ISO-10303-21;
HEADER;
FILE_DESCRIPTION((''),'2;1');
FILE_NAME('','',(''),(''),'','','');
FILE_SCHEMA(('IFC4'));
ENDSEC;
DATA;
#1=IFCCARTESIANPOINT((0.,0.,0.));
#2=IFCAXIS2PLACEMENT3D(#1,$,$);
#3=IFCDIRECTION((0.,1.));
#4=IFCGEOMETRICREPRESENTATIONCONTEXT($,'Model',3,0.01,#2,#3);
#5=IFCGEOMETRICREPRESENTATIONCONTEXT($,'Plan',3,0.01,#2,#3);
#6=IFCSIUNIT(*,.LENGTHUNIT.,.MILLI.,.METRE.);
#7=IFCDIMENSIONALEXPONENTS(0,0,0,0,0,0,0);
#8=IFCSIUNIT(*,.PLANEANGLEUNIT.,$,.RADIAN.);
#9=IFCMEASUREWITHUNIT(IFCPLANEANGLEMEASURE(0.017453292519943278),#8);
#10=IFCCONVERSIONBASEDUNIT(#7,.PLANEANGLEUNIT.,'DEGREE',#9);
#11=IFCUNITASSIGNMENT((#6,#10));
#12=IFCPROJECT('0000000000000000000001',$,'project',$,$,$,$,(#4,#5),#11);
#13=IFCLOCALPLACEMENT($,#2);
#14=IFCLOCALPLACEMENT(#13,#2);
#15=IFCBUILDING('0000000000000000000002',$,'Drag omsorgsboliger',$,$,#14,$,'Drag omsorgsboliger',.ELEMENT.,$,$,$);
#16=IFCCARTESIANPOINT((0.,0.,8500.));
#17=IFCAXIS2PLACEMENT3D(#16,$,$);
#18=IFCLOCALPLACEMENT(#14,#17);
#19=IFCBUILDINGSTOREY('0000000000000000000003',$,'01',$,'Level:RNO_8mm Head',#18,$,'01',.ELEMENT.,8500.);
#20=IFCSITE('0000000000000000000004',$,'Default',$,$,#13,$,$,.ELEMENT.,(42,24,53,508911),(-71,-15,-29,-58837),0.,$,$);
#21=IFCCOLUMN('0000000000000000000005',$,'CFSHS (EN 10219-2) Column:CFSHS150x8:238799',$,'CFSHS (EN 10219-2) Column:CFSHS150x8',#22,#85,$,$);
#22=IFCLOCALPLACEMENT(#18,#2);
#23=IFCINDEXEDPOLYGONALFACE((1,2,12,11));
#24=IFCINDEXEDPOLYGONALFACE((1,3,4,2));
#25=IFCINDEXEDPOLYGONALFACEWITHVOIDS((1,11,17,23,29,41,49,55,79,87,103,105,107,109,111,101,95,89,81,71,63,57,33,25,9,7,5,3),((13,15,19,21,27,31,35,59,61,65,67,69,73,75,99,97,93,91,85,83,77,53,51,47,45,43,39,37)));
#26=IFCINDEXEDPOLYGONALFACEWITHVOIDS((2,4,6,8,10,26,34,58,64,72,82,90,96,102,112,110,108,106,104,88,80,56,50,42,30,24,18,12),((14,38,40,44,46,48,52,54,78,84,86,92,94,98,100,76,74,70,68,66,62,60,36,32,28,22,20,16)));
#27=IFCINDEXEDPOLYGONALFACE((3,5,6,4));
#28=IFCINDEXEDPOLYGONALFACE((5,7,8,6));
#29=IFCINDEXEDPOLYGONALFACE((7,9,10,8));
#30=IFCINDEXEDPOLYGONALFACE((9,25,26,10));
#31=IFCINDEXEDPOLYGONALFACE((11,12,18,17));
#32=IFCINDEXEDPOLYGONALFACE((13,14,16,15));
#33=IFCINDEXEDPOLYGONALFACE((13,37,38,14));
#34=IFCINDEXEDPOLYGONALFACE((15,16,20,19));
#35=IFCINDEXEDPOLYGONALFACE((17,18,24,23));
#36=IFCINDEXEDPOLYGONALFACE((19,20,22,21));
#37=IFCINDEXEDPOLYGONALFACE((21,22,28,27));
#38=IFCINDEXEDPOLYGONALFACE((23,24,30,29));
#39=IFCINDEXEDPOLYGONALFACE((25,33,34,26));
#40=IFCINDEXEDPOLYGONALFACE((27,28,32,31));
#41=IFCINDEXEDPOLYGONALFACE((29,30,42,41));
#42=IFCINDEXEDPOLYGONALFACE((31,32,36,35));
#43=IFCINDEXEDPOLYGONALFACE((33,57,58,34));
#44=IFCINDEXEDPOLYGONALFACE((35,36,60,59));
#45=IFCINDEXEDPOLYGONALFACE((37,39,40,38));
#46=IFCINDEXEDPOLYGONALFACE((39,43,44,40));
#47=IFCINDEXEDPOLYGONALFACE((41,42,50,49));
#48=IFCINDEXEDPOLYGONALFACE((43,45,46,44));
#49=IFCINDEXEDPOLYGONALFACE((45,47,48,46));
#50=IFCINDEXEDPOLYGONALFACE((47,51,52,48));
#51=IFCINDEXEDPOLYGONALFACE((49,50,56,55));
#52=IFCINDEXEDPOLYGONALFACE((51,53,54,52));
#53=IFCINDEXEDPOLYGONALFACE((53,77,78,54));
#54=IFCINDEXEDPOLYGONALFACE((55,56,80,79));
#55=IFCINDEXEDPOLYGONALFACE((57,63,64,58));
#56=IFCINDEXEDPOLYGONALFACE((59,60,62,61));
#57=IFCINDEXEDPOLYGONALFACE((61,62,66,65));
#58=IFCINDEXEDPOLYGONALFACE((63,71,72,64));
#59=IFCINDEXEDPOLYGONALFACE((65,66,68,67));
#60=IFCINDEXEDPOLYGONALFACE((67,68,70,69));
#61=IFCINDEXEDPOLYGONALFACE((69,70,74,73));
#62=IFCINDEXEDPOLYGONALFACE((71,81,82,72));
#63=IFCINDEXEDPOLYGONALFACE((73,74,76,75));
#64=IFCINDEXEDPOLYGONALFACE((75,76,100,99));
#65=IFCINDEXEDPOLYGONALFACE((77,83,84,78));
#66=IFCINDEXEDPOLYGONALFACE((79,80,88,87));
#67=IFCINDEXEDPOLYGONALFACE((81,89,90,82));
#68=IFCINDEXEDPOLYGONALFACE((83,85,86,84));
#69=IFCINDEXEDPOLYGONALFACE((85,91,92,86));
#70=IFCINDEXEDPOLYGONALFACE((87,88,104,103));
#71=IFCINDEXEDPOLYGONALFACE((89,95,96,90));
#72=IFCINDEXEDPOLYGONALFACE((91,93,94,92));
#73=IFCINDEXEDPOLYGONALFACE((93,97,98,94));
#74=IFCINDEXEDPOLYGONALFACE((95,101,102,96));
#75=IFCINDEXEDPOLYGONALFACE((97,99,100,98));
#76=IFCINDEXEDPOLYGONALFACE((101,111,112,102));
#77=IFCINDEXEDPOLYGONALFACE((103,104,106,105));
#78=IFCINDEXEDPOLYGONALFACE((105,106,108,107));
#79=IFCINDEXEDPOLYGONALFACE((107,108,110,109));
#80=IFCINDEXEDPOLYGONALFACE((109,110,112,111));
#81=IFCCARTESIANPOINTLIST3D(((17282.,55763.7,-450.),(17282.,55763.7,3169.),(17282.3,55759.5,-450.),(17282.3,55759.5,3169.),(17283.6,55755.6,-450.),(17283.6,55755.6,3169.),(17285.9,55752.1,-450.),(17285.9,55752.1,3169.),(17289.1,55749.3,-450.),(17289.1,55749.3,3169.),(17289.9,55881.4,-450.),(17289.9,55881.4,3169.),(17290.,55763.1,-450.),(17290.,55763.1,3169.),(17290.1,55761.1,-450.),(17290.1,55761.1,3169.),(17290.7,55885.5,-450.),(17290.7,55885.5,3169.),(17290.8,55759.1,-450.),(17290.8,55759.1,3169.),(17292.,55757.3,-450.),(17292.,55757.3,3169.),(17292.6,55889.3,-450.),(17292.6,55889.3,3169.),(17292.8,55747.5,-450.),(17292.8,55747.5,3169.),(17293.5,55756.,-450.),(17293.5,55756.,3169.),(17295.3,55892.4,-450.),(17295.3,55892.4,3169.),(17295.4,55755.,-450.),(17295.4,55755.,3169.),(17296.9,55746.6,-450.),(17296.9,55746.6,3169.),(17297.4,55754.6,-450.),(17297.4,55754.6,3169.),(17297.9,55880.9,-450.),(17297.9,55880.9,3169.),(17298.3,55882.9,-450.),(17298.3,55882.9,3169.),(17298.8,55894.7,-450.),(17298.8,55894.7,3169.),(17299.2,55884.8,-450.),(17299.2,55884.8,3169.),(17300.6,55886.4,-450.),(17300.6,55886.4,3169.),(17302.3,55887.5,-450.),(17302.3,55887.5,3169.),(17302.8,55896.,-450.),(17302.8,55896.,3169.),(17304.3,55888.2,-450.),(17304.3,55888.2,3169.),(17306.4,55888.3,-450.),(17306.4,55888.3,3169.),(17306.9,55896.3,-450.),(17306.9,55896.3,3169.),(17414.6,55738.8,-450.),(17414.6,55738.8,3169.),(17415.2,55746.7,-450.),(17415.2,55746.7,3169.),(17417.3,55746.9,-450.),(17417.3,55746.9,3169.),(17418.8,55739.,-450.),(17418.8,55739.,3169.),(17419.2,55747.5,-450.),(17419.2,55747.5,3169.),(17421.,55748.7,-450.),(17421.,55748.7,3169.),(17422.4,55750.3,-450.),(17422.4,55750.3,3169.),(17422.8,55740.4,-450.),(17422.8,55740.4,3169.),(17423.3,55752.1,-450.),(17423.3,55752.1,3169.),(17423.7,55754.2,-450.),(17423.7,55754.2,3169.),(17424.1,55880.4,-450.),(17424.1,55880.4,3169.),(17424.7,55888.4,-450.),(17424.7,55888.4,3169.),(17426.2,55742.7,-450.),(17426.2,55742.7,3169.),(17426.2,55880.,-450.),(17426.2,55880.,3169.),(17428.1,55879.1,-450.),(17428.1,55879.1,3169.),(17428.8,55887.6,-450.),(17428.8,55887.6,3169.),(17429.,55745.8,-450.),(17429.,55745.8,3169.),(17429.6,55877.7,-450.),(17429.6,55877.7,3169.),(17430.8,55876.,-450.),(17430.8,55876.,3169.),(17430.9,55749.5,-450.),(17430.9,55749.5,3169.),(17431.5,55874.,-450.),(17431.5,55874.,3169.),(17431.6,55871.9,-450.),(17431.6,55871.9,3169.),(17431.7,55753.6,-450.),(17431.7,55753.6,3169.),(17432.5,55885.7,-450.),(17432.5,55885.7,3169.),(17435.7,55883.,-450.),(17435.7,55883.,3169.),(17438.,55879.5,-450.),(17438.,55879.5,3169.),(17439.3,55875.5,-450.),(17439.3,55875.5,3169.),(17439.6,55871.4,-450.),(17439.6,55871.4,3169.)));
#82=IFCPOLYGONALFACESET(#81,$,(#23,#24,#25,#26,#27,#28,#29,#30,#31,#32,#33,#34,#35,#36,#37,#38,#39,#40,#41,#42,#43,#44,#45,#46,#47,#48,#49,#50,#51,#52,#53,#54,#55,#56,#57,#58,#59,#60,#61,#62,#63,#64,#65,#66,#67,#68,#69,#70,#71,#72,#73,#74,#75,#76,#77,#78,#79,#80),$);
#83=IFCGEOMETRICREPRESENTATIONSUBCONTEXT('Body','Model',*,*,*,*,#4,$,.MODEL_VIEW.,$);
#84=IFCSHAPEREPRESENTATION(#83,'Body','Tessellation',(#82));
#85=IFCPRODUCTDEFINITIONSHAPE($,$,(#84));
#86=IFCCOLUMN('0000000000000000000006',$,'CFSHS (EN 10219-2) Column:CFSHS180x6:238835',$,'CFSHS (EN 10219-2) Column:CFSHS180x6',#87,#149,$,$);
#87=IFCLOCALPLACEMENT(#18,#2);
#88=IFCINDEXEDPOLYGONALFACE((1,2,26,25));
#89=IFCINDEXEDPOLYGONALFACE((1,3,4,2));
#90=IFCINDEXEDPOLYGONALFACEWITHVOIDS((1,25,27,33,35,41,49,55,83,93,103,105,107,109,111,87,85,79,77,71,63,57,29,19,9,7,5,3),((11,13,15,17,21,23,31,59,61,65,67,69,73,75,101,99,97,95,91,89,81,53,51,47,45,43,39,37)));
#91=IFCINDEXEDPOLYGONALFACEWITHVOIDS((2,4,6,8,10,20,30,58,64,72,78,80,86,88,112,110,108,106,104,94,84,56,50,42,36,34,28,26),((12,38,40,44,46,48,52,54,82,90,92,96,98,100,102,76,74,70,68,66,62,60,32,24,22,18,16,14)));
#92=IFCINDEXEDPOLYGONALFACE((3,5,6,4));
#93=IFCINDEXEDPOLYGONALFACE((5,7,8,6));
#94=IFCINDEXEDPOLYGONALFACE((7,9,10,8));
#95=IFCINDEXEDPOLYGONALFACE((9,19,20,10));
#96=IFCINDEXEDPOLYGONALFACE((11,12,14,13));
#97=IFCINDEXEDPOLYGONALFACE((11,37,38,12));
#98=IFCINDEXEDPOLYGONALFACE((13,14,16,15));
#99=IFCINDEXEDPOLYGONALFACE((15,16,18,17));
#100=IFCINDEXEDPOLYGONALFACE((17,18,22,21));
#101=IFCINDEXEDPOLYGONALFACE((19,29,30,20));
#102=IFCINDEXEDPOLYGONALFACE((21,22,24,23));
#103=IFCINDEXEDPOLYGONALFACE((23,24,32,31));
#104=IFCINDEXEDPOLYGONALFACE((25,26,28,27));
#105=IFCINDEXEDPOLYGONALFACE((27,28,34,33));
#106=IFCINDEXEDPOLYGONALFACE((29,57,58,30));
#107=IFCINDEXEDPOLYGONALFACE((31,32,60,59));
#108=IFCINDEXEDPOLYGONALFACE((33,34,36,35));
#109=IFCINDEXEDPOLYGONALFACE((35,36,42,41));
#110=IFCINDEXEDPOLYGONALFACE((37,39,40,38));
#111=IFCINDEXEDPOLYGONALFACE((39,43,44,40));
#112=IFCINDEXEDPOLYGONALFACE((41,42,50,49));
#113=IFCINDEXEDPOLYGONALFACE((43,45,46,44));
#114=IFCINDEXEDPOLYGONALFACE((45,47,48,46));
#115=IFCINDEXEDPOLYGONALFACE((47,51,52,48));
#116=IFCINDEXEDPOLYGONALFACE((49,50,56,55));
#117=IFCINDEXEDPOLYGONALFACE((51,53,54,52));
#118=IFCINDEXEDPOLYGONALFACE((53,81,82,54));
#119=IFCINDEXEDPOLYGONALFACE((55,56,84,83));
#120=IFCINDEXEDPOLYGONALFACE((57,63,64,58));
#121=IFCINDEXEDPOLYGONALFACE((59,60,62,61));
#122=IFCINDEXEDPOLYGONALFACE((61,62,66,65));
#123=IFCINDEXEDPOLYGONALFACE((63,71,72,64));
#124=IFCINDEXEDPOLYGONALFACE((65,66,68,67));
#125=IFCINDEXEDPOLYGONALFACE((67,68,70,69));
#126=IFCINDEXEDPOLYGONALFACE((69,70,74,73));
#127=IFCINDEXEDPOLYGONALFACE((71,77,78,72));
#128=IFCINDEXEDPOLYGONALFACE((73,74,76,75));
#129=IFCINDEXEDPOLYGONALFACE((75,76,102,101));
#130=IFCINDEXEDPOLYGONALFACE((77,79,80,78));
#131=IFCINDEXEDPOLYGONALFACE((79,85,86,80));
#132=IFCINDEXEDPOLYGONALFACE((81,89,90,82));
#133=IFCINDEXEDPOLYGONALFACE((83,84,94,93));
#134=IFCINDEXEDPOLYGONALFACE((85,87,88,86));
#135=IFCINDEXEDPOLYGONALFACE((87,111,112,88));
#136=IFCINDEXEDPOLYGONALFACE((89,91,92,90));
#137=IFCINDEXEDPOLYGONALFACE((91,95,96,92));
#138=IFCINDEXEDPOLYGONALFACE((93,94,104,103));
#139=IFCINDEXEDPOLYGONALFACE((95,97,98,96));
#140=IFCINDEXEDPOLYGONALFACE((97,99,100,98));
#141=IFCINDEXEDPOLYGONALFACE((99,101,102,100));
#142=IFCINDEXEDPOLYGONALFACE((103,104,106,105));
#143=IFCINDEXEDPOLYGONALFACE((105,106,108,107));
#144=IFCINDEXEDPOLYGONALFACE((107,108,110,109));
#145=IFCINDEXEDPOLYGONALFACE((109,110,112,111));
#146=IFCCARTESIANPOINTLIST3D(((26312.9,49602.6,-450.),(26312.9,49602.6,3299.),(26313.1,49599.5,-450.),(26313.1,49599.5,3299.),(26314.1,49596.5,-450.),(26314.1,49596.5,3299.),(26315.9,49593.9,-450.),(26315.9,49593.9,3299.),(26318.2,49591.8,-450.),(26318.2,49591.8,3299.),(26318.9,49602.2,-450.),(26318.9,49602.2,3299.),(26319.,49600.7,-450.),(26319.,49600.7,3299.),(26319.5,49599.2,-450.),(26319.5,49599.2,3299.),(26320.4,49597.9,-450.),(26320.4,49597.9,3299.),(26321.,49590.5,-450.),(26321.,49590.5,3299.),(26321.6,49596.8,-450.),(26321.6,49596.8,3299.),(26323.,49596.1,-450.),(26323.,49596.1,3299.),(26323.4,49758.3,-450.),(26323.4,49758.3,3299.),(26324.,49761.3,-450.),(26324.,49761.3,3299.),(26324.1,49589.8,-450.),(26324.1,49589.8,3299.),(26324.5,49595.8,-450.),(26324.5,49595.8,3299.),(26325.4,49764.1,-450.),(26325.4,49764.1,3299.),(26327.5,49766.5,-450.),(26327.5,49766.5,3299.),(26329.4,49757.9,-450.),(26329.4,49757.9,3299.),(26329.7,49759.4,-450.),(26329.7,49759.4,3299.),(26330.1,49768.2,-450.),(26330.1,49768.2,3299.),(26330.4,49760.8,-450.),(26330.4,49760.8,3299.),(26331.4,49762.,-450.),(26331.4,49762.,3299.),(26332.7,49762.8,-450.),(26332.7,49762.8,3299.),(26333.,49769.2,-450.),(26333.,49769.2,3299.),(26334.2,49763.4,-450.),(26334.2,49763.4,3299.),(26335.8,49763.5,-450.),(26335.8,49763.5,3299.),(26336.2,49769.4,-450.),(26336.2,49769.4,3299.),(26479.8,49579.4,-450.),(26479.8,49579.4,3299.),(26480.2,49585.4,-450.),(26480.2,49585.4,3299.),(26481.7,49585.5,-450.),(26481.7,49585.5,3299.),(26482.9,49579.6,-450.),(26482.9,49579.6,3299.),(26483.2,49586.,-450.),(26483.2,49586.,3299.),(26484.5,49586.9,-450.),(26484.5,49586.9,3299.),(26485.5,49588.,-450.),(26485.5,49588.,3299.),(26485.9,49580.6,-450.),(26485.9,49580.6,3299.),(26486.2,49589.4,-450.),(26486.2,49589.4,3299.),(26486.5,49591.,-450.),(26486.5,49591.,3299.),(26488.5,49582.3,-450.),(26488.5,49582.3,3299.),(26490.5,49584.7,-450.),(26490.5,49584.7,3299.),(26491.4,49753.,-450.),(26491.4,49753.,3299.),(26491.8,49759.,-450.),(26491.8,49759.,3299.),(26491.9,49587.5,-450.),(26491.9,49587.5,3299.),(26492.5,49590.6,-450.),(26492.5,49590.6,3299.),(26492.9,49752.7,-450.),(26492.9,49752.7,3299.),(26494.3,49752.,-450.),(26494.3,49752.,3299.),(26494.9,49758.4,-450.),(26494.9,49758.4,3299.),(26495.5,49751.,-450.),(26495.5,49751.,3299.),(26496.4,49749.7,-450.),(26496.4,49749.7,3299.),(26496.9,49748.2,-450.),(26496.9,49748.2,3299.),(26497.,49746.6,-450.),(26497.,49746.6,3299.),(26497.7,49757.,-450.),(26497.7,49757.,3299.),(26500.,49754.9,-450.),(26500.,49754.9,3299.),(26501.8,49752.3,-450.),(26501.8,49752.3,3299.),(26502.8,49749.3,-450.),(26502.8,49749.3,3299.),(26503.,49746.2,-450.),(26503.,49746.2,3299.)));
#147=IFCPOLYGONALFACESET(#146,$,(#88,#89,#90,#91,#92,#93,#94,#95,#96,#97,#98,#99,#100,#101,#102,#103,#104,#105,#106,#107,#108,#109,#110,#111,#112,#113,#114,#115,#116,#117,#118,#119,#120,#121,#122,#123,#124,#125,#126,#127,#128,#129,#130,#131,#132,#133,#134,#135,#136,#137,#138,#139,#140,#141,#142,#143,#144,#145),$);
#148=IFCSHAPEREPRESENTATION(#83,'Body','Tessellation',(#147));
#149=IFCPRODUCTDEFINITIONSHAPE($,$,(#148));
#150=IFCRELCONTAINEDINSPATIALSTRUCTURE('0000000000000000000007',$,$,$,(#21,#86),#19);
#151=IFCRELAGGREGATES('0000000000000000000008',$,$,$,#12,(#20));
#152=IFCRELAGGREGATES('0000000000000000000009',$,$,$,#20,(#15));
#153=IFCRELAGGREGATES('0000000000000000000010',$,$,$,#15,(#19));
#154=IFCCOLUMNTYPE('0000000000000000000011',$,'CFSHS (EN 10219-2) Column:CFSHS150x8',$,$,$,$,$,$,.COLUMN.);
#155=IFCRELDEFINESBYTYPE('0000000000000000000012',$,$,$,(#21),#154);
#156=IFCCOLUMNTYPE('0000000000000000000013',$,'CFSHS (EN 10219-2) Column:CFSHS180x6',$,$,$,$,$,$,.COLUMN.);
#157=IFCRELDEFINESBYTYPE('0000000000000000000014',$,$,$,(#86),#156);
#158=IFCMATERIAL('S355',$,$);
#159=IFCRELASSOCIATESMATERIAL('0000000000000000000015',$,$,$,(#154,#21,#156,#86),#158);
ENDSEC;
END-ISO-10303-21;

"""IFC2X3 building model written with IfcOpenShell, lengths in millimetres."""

from ifc_helpers import new_model, entity, si_unit, converted_unit, direction, frame, frame_2d, origin, place, context, subcontext, project, spatial, polyline, circle_curve, parameter, trimmed, segment, composite_curve, outline, extrude, source, transform, mapped, material, type_object, type_shapes, element, save


model = new_model("IFC2X3")

# Units and contexts
model_context = context("Model", 3, precision=0.01, world=origin(), true_north=direction((0.0, 1.0)))
plan_context = context("Plan", 3, precision=0.01, world=origin(), true_north=direction((0.0, 1.0)))
body_context = subcontext(model_context, "Body", "Model", "MODEL_VIEW")
ifc_project = project(units=[si_unit("LENGTHUNIT", "METRE", prefix="MILLI"), converted_unit("PLANEANGLEUNIT", "DEGREE", entity("IfcPlaneAngleMeasure", 0.017453292519943278), si_unit("PLANEANGLEUNIT", "RADIAN"), dimensions=[0, 0, 0, 0, 0, 0, 0])], contexts=[model_context, plan_context])

# Site, building, storey
site_placement = place(None, origin())
site = spatial("IfcSite", under=ifc_project, at=site_placement, Name="Default", CompositionType="ELEMENT", RefLatitude=(42, 24, 53, 508911), RefLongitude=(-71, -15, -29, -58837), RefElevation=0.0)
building_placement = place(site_placement, origin())
building = spatial("IfcBuilding", under=site, at=building_placement, Name="Drag omsorgsboliger", LongName="Drag omsorgsboliger", CompositionType="ELEMENT")
storey_placement = place(building_placement, frame((0.0, 0.0, 8500.0)))
storey = spatial("IfcBuildingStorey", under=building, at=storey_placement, Name="01", ObjectType="Level:RNO_8mm Head", LongName="01", CompositionType="ELEMENT", Elevation=8500.0)

# Columns
ifc_material = material(Name="S355")
column_type_1 = type_object("IfcColumnType", Name="CFSHS (EN 10219-2) Column:CFSHS150x8", PredefinedType="COLUMN", material=ifc_material)
shared_shape_1 = source(origin(), body_context, "Body", "SweptSolid", [
    extrude(outline(composite_curve([segment(polyline([(-59.0, -75.0), (59.0, -75.0)]), True, "CONTINUOUS"), segment(trimmed(circle_curve(frame_2d((59.0, -59.0), x_axis=(-1.0, 0.0)), 16.0), [parameter(90.0)], [parameter(180.0)], True, "PARAMETER"), True, "CONTINUOUS"), segment(polyline([(75.0, -59.0), (75.0, 59.0)]), True, "CONTINUOUS"), segment(trimmed(circle_curve(frame_2d((59.0, 59.0), x_axis=(-1.0, 0.0)), 16.0), [parameter(180.0)], [parameter(270.0)], True, "PARAMETER"), True, "CONTINUOUS"), segment(polyline([(59.0, 75.0), (-59.0, 75.0)]), True, "CONTINUOUS"), segment(trimmed(circle_curve(frame_2d((-59.0, 59.0), x_axis=(-1.0, 0.0)), 16.0), [parameter(270.0)], [parameter(360.0)], True, "PARAMETER"), True, "CONTINUOUS"), segment(polyline([(-75.0, 59.0), (-75.0, -59.0)]), True, "CONTINUOUS"), segment(trimmed(circle_curve(frame_2d((-59.0, -59.0), x_axis=(-1.0, 0.0)), 16.0), [parameter(360.0)], [parameter(90.0)], True, "PARAMETER"), True, "CONTINUOUS")], self_intersect=False), holes=[composite_curve([segment(trimmed(circle_curve(frame_2d((-59.0, -59.0), x_axis=(-1.0, 0.0)), 8.0), [parameter(360.0)], [parameter(90.0)], True, "PARAMETER"), False, "CONTINUOUS"), segment(polyline([(-67.0, -59.0), (-67.0, 59.0)]), True, "CONTINUOUS"), segment(trimmed(circle_curve(frame_2d((-59.0, 59.0), x_axis=(-1.0, 0.0)), 8.0), [parameter(270.0)], [parameter(360.0)], True, "PARAMETER"), False, "CONTINUOUS"), segment(polyline([(-59.0, 67.0), (59.0, 67.0)]), True, "CONTINUOUS"), segment(trimmed(circle_curve(frame_2d((59.0, 59.0), x_axis=(-1.0, 0.0)), 8.0), [parameter(180.0)], [parameter(270.0)], True, "PARAMETER"), False, "CONTINUOUS"), segment(polyline([(67.0, 59.0), (67.0, -59.0)]), True, "CONTINUOUS"), segment(trimmed(circle_curve(frame_2d((59.0, -59.0), x_axis=(-1.0, 0.0)), 8.0), [parameter(90.0)], [parameter(180.0)], True, "PARAMETER"), False, "CONTINUOUS"), segment(polyline([(59.0, -67.0), (-59.0, -67.0)]), True, "CONTINUOUS")], self_intersect=False)]), frame((17360.8, 55817.5, 8050.0), z_axis=(0.0, 0.0, 1.0), x_axis=(-0.997758, 0.066923, 0.0)), (0.0, 0.0, 1.0), 3619.0),
])
type_shapes(column_type_1, [shared_shape_1])
column_1_placement = place(storey_placement, frame((0.0, 0.0, -8500.0)))
element("IfcColumn", 1, at=column_1_placement, inside=storey, type_object=column_type_1, material=ifc_material, Name="CFSHS (EN 10219-2) Column:CFSHS150x8:238799", ObjectType="CFSHS (EN 10219-2) Column:CFSHS150x8", context=body_context, shape_type="MappedRepresentation", body=[
    mapped(shared_shape_1, transform((0.0, 0.0, 0.0), scale=1.0)),
])
column_type_2 = type_object("IfcColumnType", Name="CFSHS (EN 10219-2) Column:CFSHS180x6", PredefinedType="COLUMN", material=ifc_material)
shared_shape_2 = source(origin(), body_context, "Body", "SweptSolid", [
    extrude(outline(composite_curve([segment(polyline([(-78.0, -90.0), (78.0, -90.0)]), True, "CONTINUOUS"), segment(trimmed(circle_curve(frame_2d((78.0, -78.0), x_axis=(-1.0, 0.0)), 12.0), [parameter(90.0)], [parameter(180.0)], True, "PARAMETER"), True, "CONTINUOUS"), segment(polyline([(90.0, -78.0), (90.0, 78.0)]), True, "CONTINUOUS"), segment(trimmed(circle_curve(frame_2d((78.0, 78.0), x_axis=(-1.0, 0.0)), 12.0), [parameter(180.0)], [parameter(270.0)], True, "PARAMETER"), True, "CONTINUOUS"), segment(polyline([(78.0, 90.0), (-78.0, 90.0)]), True, "CONTINUOUS"), segment(trimmed(circle_curve(frame_2d((-78.0, 78.0), x_axis=(-1.0, 0.0)), 12.0), [parameter(270.0)], [parameter(360.0)], True, "PARAMETER"), True, "CONTINUOUS"), segment(polyline([(-90.0, 78.0), (-90.0, -78.0)]), True, "CONTINUOUS"), segment(trimmed(circle_curve(frame_2d((-78.0, -78.0), x_axis=(-1.0, 0.0)), 12.0), [parameter(360.0)], [parameter(90.0)], True, "PARAMETER"), True, "CONTINUOUS")], self_intersect=False), holes=[composite_curve([segment(trimmed(circle_curve(frame_2d((-78.0, -78.0), x_axis=(-1.0, 0.0)), 6.0), [parameter(360.0)], [parameter(90.0)], True, "PARAMETER"), False, "CONTINUOUS"), segment(polyline([(-84.0, -78.0), (-84.0, 78.0)]), True, "CONTINUOUS"), segment(trimmed(circle_curve(frame_2d((-78.0, 78.0), x_axis=(-1.0, 0.0)), 6.0), [parameter(270.0)], [parameter(360.0)], True, "PARAMETER"), False, "CONTINUOUS"), segment(polyline([(-78.0, 84.0), (78.0, 84.0)]), True, "CONTINUOUS"), segment(trimmed(circle_curve(frame_2d((78.0, 78.0), x_axis=(-1.0, 0.0)), 6.0), [parameter(180.0)], [parameter(270.0)], True, "PARAMETER"), False, "CONTINUOUS"), segment(polyline([(84.0, 78.0), (84.0, -78.0)]), True, "CONTINUOUS"), segment(trimmed(circle_curve(frame_2d((78.0, -78.0), x_axis=(-1.0, 0.0)), 6.0), [parameter(90.0)], [parameter(180.0)], True, "PARAMETER"), False, "CONTINUOUS"), segment(polyline([(78.0, -84.0), (-78.0, -84.0)]), True, "CONTINUOUS")], self_intersect=False)]), frame((26408.0, 49674.4, 8050.0), z_axis=(0.0, 0.0, 1.0), x_axis=(-0.997758, 0.066923, 0.0)), (0.0, 0.0, 1.0), 3749.0),
])
type_shapes(column_type_2, [shared_shape_2])
column_2_placement = place(storey_placement, frame((0.0, 0.0, -8500.0)))
element("IfcColumn", 2, at=column_2_placement, inside=storey, type_object=column_type_2, material=ifc_material, Name="CFSHS (EN 10219-2) Column:CFSHS180x6:238835", ObjectType="CFSHS (EN 10219-2) Column:CFSHS180x6", context=body_context, shape_type="MappedRepresentation", body=[
    mapped(shared_shape_2, transform((0.0, 0.0, 0.0), scale=1.0)),
])

save(model, "model.ifc")
